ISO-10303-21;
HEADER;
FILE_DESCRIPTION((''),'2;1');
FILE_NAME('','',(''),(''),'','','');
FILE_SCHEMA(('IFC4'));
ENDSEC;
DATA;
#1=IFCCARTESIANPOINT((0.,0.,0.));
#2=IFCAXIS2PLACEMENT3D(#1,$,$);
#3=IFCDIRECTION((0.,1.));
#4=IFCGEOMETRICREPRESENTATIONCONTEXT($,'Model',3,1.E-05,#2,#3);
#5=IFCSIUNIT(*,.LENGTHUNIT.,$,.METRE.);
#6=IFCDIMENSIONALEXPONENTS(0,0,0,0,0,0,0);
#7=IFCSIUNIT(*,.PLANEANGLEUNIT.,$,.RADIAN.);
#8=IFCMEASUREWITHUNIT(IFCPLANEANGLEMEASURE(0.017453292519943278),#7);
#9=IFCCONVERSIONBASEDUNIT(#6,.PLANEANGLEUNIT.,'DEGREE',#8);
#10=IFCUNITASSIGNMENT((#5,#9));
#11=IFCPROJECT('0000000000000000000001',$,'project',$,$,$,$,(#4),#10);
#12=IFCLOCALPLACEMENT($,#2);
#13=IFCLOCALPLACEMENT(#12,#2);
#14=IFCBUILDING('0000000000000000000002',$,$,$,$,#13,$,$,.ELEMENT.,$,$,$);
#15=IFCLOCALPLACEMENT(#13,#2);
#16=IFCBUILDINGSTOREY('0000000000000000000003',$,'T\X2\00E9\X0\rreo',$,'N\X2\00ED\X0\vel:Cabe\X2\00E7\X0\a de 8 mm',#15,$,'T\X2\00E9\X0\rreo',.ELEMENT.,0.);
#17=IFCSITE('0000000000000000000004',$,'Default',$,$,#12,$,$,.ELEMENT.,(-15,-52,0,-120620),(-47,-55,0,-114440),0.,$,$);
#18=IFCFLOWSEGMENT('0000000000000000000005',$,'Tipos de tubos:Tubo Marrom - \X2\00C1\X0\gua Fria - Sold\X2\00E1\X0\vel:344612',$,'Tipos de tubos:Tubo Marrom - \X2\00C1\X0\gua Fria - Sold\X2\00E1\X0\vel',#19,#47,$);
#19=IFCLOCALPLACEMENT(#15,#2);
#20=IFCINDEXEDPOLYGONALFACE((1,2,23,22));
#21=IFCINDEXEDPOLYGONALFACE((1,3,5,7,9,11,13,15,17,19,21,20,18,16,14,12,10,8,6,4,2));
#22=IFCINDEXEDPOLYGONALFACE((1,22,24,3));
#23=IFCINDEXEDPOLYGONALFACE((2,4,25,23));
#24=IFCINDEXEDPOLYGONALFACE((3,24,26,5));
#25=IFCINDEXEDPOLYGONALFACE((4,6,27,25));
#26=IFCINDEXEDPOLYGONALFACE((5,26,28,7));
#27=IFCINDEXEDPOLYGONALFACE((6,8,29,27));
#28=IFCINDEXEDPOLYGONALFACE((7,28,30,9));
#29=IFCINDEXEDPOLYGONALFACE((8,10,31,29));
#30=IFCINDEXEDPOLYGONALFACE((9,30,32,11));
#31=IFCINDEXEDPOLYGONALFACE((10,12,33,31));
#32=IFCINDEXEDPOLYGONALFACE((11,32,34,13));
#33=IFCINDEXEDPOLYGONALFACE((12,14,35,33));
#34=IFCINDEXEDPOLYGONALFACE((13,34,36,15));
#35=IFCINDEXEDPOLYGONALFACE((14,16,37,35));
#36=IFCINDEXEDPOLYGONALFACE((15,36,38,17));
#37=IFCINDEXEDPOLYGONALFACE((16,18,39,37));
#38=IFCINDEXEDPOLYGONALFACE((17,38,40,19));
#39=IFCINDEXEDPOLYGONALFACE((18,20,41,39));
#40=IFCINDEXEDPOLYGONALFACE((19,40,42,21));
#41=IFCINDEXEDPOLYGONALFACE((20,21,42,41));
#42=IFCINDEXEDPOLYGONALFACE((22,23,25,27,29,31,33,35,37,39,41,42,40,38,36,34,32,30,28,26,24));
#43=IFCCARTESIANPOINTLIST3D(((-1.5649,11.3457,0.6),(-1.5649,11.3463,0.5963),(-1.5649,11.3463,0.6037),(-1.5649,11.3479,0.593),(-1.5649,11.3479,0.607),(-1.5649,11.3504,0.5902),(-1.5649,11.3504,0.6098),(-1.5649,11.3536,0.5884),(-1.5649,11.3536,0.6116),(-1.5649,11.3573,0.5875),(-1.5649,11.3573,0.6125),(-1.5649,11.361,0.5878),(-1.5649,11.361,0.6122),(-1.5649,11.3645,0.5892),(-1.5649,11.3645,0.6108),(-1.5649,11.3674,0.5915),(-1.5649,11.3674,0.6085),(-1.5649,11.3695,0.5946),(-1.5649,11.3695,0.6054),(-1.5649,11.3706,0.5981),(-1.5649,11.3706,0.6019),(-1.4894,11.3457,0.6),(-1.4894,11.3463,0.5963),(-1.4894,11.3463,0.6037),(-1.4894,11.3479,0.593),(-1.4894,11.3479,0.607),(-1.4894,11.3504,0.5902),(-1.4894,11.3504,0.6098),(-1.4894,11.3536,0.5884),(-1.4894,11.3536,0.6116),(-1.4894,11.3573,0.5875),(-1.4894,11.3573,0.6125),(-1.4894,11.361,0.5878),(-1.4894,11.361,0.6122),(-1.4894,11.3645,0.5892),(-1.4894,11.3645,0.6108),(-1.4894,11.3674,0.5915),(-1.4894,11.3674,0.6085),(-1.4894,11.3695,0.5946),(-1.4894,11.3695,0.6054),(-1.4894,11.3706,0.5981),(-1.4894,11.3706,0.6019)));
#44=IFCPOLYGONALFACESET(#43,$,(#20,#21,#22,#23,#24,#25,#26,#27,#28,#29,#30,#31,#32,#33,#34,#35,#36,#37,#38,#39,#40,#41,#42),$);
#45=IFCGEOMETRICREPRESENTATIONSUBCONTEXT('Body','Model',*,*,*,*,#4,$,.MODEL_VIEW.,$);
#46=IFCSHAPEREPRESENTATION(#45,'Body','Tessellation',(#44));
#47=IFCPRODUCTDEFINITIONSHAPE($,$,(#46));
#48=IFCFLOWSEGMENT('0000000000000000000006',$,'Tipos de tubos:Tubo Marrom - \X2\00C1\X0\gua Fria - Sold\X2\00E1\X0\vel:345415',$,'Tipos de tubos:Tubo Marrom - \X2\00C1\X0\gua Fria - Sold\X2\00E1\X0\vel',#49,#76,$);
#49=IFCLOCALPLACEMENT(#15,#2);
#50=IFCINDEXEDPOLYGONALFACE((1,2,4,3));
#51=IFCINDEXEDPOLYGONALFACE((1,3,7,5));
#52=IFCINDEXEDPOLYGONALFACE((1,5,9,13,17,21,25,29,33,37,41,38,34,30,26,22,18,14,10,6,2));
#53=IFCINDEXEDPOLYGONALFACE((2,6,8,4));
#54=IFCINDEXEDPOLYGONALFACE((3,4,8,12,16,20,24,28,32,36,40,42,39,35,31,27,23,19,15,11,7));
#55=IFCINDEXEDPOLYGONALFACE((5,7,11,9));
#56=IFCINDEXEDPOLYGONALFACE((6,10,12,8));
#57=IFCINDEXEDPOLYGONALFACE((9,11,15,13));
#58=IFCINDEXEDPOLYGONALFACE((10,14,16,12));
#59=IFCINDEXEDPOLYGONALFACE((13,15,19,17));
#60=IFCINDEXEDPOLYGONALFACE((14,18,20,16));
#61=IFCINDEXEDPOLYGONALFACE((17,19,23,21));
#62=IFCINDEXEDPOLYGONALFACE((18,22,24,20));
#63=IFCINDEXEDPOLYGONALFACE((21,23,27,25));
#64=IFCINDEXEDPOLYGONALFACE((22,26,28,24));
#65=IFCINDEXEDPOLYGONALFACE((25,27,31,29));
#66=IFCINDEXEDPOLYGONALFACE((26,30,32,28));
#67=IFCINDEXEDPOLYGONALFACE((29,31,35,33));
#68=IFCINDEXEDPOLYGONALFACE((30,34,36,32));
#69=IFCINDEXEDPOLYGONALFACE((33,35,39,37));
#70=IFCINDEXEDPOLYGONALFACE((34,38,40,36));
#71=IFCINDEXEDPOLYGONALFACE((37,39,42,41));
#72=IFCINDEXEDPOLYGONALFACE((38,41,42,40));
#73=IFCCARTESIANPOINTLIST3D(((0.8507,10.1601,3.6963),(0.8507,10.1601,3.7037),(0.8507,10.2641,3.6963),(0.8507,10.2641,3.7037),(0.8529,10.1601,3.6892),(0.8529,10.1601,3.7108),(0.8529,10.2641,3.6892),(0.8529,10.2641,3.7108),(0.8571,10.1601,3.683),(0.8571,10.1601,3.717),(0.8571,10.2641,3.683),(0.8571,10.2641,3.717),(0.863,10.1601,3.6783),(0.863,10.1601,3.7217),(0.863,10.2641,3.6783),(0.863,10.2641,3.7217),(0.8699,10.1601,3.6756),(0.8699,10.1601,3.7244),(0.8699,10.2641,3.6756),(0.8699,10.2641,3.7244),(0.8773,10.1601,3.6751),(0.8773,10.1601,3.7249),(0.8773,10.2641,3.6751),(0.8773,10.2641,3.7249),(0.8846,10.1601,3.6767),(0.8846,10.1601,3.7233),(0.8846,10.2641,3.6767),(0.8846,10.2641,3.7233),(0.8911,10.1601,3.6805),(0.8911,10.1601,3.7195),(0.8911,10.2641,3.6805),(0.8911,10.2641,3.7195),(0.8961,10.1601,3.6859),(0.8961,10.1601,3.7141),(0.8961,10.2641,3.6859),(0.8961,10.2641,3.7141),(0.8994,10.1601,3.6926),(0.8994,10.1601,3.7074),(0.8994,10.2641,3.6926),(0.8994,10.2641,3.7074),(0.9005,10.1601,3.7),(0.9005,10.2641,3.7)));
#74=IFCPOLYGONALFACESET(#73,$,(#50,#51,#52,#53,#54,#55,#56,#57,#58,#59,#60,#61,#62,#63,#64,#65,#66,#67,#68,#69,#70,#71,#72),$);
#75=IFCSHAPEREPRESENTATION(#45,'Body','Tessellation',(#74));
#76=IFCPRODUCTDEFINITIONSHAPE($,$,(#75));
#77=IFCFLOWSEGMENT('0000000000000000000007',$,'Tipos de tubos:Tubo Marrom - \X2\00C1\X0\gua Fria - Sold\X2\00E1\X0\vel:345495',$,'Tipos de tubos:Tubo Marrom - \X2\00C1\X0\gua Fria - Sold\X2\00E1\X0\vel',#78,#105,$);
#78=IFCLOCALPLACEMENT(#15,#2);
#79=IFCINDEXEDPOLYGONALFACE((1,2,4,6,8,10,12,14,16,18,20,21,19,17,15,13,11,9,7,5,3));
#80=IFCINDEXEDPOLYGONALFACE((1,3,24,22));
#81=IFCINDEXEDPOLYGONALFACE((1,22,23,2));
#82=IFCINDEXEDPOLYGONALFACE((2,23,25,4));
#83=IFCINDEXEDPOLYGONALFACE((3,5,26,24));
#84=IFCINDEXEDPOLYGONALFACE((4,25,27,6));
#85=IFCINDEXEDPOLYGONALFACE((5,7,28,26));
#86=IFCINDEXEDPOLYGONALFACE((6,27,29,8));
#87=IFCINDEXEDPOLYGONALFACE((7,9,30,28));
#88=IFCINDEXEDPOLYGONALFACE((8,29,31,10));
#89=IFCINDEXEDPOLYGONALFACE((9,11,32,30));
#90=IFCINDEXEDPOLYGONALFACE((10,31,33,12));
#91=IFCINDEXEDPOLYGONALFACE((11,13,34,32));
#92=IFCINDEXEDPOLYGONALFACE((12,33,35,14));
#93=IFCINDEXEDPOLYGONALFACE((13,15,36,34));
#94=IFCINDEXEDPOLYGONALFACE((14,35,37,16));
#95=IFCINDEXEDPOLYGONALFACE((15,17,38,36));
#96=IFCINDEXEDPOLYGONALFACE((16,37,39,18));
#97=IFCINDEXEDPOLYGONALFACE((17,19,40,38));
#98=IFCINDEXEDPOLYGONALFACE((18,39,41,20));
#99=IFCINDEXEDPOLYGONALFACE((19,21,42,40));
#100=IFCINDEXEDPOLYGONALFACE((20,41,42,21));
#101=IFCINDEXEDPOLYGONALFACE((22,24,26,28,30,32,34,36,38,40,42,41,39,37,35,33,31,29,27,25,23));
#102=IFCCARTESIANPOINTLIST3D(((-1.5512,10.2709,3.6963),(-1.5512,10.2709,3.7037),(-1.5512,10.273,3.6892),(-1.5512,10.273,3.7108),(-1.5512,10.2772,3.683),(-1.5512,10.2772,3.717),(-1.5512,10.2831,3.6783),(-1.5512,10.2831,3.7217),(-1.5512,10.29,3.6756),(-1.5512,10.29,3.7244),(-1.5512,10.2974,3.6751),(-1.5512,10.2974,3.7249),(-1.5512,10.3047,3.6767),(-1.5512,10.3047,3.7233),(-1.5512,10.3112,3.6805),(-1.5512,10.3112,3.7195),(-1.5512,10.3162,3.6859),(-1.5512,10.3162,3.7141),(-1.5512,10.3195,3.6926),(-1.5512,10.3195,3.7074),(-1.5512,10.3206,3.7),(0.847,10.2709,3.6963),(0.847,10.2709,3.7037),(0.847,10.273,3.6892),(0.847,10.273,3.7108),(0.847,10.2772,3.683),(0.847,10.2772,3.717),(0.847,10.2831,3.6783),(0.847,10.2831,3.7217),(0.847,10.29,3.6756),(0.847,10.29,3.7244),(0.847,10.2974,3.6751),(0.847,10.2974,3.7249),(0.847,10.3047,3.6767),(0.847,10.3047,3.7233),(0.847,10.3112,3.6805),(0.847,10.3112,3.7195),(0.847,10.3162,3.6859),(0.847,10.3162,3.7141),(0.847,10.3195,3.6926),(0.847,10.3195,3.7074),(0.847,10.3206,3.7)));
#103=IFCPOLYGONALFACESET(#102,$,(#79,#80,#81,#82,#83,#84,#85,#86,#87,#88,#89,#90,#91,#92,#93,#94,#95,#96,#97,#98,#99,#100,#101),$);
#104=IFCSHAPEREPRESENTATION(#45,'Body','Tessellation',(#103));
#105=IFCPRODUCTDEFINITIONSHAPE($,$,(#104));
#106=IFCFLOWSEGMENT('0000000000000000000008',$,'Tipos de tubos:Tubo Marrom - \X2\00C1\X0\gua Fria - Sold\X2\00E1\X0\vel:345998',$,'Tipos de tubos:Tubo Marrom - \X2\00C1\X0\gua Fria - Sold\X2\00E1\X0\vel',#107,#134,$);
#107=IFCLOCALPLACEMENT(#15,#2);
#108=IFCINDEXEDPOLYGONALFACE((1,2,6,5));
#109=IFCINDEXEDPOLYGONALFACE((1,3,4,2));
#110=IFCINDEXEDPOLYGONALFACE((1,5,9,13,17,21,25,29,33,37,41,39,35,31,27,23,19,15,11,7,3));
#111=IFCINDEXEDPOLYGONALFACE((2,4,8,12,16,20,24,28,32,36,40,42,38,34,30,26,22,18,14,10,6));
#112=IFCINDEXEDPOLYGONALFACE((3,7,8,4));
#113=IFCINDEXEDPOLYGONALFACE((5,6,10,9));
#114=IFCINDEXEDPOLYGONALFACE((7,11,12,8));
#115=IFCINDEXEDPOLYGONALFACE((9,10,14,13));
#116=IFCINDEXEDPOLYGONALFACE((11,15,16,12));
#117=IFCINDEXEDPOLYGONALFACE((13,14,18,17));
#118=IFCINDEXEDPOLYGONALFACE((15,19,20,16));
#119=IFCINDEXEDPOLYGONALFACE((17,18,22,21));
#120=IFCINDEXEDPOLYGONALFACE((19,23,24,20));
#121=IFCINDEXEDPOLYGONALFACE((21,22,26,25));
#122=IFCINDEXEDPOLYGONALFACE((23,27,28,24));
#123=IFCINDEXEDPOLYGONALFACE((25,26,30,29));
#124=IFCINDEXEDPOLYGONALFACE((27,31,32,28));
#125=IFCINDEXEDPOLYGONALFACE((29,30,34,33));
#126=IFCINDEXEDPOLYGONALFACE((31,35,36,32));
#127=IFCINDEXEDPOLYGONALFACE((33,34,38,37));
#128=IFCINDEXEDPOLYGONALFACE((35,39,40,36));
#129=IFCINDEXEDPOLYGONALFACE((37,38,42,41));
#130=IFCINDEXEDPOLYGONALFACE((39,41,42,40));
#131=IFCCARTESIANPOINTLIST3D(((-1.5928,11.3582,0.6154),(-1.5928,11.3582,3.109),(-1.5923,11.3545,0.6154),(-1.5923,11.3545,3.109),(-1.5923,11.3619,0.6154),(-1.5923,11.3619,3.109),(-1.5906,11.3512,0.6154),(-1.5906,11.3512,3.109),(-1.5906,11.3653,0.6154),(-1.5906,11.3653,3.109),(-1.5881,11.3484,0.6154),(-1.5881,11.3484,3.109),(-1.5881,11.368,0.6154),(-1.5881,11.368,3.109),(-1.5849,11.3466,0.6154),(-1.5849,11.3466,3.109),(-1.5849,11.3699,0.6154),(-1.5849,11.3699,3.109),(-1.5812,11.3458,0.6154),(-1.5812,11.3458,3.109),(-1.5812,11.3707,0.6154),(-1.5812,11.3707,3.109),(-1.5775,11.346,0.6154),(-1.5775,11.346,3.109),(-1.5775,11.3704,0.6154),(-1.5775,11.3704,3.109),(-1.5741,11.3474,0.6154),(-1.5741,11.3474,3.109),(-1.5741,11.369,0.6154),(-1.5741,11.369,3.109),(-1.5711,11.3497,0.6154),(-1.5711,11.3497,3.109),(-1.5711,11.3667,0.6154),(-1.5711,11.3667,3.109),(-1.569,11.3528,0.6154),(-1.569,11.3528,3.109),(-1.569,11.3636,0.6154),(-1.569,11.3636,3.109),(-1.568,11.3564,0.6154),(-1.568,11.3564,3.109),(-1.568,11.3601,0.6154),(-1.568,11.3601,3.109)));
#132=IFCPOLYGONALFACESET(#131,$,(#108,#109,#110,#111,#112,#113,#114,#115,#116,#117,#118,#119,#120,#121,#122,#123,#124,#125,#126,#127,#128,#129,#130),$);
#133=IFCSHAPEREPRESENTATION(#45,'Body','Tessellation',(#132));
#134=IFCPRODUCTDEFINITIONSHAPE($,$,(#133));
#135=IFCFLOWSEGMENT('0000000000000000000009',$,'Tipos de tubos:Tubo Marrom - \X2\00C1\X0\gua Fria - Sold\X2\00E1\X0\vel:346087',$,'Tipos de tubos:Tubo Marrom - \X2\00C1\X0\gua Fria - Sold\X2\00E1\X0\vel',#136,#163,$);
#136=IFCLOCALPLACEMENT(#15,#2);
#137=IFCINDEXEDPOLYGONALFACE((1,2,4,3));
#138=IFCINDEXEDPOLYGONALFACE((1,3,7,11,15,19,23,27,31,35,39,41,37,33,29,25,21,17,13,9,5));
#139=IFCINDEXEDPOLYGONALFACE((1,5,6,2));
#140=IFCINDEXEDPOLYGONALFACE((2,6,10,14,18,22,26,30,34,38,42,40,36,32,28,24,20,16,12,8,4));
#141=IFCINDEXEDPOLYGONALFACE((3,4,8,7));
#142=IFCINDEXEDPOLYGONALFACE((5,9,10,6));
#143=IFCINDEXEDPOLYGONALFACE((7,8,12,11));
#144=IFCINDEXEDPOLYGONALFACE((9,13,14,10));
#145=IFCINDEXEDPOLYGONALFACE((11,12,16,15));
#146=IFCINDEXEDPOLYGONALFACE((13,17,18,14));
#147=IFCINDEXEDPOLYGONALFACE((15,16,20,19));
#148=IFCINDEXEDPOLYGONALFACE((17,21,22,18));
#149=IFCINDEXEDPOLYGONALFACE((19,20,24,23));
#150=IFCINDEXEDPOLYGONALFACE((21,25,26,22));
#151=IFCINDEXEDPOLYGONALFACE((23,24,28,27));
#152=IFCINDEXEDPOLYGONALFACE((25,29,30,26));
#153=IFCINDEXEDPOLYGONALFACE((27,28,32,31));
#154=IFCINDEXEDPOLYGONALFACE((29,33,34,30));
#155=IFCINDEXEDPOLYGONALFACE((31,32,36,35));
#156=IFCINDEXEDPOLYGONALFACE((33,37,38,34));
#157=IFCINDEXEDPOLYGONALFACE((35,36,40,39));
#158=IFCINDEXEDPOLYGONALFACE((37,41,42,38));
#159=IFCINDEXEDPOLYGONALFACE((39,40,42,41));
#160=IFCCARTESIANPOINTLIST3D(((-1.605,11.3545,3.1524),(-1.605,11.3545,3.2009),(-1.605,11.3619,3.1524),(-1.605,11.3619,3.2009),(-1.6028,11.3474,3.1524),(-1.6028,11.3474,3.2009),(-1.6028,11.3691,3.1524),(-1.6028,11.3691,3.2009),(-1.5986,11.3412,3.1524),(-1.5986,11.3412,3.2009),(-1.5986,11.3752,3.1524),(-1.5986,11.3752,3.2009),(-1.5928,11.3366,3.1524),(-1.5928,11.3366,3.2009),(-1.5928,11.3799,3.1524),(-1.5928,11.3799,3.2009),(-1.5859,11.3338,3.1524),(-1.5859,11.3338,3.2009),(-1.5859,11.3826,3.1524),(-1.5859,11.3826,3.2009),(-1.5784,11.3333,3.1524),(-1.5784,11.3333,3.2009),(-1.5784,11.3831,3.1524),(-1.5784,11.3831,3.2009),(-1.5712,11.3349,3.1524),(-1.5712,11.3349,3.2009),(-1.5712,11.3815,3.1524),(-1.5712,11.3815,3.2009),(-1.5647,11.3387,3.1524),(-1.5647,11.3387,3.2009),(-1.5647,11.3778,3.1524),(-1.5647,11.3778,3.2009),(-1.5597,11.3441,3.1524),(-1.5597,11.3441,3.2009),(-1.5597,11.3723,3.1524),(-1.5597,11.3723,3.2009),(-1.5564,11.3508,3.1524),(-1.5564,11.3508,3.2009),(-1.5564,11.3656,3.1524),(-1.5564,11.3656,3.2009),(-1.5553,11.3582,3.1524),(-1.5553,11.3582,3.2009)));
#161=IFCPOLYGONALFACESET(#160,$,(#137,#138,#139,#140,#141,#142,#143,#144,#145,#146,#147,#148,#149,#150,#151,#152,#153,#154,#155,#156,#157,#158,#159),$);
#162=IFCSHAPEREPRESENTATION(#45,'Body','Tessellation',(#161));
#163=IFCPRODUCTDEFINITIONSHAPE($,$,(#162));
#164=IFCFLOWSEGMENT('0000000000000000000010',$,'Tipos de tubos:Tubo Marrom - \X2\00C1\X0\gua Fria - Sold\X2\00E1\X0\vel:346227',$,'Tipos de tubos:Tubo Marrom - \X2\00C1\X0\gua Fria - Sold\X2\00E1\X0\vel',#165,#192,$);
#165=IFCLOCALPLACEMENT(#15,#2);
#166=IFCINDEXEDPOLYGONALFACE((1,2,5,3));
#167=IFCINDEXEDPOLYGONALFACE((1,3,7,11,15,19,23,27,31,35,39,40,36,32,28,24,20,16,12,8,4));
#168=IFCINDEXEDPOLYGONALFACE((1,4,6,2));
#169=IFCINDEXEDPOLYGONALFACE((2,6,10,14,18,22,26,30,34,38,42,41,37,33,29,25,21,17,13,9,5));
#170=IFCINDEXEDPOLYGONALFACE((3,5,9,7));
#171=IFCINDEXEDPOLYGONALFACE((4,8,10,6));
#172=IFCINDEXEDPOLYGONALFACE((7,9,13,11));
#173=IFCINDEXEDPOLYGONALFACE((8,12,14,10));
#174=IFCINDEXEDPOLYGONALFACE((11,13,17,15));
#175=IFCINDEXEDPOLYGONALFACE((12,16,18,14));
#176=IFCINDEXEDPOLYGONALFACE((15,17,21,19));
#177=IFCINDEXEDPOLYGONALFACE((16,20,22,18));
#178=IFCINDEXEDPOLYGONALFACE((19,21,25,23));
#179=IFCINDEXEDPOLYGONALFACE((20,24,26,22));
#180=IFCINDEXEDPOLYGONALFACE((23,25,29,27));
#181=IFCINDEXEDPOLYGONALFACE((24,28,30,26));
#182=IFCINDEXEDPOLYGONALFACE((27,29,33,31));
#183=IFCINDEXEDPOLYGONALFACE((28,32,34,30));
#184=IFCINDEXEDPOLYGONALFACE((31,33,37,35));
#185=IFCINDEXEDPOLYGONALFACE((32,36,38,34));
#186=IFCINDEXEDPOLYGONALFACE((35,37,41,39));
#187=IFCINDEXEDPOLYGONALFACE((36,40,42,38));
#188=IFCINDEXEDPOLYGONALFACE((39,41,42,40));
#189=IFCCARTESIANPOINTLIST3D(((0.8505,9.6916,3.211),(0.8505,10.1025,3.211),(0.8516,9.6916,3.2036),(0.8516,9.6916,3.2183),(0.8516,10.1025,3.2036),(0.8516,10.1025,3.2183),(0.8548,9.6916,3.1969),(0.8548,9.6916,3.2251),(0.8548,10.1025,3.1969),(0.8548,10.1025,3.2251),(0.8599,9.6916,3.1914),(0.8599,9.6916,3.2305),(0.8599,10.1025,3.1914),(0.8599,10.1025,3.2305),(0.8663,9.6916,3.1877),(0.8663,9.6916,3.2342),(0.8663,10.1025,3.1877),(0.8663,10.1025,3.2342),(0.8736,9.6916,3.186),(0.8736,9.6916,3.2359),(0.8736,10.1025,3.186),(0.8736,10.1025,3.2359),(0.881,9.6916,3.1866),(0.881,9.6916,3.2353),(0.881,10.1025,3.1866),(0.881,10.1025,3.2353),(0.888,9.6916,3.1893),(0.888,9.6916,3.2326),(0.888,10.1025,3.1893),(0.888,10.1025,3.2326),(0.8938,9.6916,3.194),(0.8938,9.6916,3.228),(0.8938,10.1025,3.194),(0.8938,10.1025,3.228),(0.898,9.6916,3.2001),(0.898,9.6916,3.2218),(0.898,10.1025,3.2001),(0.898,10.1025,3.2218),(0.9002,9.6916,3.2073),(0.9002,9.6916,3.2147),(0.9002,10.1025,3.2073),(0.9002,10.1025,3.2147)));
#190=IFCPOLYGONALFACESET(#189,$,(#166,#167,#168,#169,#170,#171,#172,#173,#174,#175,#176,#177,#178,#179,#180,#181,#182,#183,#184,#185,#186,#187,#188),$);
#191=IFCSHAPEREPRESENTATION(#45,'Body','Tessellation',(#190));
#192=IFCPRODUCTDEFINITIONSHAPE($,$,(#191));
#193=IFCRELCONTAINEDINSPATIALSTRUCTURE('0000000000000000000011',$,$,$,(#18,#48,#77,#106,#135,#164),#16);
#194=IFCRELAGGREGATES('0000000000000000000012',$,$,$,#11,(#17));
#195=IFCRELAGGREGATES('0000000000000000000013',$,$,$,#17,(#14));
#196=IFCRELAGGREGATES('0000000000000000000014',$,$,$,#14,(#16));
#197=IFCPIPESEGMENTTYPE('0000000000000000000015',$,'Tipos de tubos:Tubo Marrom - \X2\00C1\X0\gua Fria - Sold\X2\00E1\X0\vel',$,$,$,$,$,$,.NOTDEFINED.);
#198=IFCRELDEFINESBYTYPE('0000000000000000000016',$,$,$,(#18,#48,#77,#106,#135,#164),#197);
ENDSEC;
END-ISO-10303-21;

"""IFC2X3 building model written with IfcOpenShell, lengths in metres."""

from ifc_helpers import new_model, entity, si_unit, converted_unit, direction, frame, frame_2d, origin, origin_2d_with_axis, place, context, subcontext, project, spatial, circle, extrude, type_object, element, save


model = new_model("IFC2X3")

# Units and contexts
model_context = context("Model", 3, precision=1e-05, world=origin(), true_north=direction((0.0, 1.0)))
body_context = subcontext(model_context, "Body", "Model", "MODEL_VIEW")
ifc_project = project(units=[si_unit("LENGTHUNIT", "METRE"), converted_unit("PLANEANGLEUNIT", "DEGREE", entity("IfcPlaneAngleMeasure", 0.017453292519943278), si_unit("PLANEANGLEUNIT", "RADIAN"), dimensions=[0, 0, 0, 0, 0, 0, 0])], contexts=[model_context])

# Site, building, storey
site_placement = place(None, origin())
site = spatial("IfcSite", under=ifc_project, at=site_placement, Name="Default", CompositionType="ELEMENT", RefLatitude=(-15, -52, 0, -120620), RefLongitude=(-47, -55, 0, -114440), RefElevation=0.0)
building_placement = place(site_placement, origin())
building = spatial("IfcBuilding", under=site, at=building_placement, CompositionType="ELEMENT")
storey_placement = place(building_placement, origin())
storey = spatial("IfcBuildingStorey", under=building, at=storey_placement, Name="Térreo", ObjectType="Nível:Cabeça de 8 mm", LongName="Térreo", CompositionType="ELEMENT", Elevation=0.0)

# Flow segments
pipe_segment_type = type_object("IfcPipeSegmentType", Name="Tipos de tubos:Tubo Marrom - Água Fria - Soldável", PredefinedType="NOTDEFINED")
flow_segment_1_placement = place(storey_placement, origin())
element("IfcFlowSegment", 1, at=flow_segment_1_placement, inside=storey, type_object=pipe_segment_type, Name="Tipos de tubos:Tubo Marrom - Água Fria - Soldável:344612", ObjectType="Tipos de tubos:Tubo Marrom - Água Fria - Soldável", context=body_context, shape_type="SweptSolid", body=[
    extrude(circle(Radius=0.0125, at=origin_2d_with_axis()), frame((-1.5649, 11.3582, 0.6), z_axis=(1.0, 0.0, 0.0), x_axis=(0.0, -1.0, 0.0)), (0.0, 0.0, 1.0), 0.0755),
])
flow_segment_2_placement = place(storey_placement, origin())
element("IfcFlowSegment", 2, at=flow_segment_2_placement, inside=storey, type_object=pipe_segment_type, Name="Tipos de tubos:Tubo Marrom - Água Fria - Soldável:345415", ObjectType="Tipos de tubos:Tubo Marrom - Água Fria - Soldável", context=body_context, shape_type="SweptSolid", body=[
    extrude(circle(Radius=0.025, at=origin_2d_with_axis()), frame((0.8755, 10.1601, 3.7), z_axis=(0.0, 1.0, 0.0), x_axis=(1.0, 0.0, 0.0)), (0.0, 0.0, 1.0), 0.104),
])
flow_segment_3_placement = place(storey_placement, origin())
element("IfcFlowSegment", 3, at=flow_segment_3_placement, inside=storey, type_object=pipe_segment_type, Name="Tipos de tubos:Tubo Marrom - Água Fria - Soldável:345495", ObjectType="Tipos de tubos:Tubo Marrom - Água Fria - Soldável", context=body_context, shape_type="SweptSolid", body=[
    extrude(circle(Radius=0.025, at=frame_2d((0.0, 0.0), x_axis=(1.0, 0.0))), frame((-1.5512, 10.2956, 3.7), z_axis=(1.0, 0.0, 0.0), x_axis=(0.0, 1.0, 0.0)), (0.0, 0.0, 1.0), 2.3982),
])
flow_segment_4_placement = place(storey_placement, origin())
element("IfcFlowSegment", 4, at=flow_segment_4_placement, inside=storey, type_object=pipe_segment_type, Name="Tipos de tubos:Tubo Marrom - Água Fria - Soldável:345998", ObjectType="Tipos de tubos:Tubo Marrom - Água Fria - Soldável", context=body_context, shape_type="SweptSolid", body=[
    extrude(circle(Radius=0.0125, at=origin_2d_with_axis()), frame((-1.5803, 11.3582, 0.6154), z_axis=(0.0, 0.0, 1.0), x_axis=(-1.0, 0.0, 0.0)), (0.0, 0.0, 1.0), 2.4936),
])
flow_segment_5_placement = place(storey_placement, origin())
element("IfcFlowSegment", 5, at=flow_segment_5_placement, inside=storey, type_object=pipe_segment_type, Name="Tipos de tubos:Tubo Marrom - Água Fria - Soldável:346087", ObjectType="Tipos de tubos:Tubo Marrom - Água Fria - Soldável", context=body_context, shape_type="SweptSolid", body=[
    extrude(circle(Radius=0.025, at=origin_2d_with_axis()), frame((-1.5803, 11.3582, 3.1524)), (0.0, 0.0, 1.0), 0.0485),
])
flow_segment_6_placement = place(storey_placement, origin())
element("IfcFlowSegment", 6, at=flow_segment_6_placement, inside=storey, type_object=pipe_segment_type, Name="Tipos de tubos:Tubo Marrom - Água Fria - Soldável:346227", ObjectType="Tipos de tubos:Tubo Marrom - Água Fria - Soldável", context=body_context, shape_type="SweptSolid", body=[
    extrude(circle(Radius=0.025, at=frame_2d((0.0, 0.0), x_axis=(1.0, 0.0))), frame((0.8755, 9.6916, 3.211), z_axis=(0.0, 1.0, 0.0), x_axis=(-1.0, 0.0, 0.0)), (0.0, 0.0, 1.0), 0.4109),
])

save(model, "model.ifc")
